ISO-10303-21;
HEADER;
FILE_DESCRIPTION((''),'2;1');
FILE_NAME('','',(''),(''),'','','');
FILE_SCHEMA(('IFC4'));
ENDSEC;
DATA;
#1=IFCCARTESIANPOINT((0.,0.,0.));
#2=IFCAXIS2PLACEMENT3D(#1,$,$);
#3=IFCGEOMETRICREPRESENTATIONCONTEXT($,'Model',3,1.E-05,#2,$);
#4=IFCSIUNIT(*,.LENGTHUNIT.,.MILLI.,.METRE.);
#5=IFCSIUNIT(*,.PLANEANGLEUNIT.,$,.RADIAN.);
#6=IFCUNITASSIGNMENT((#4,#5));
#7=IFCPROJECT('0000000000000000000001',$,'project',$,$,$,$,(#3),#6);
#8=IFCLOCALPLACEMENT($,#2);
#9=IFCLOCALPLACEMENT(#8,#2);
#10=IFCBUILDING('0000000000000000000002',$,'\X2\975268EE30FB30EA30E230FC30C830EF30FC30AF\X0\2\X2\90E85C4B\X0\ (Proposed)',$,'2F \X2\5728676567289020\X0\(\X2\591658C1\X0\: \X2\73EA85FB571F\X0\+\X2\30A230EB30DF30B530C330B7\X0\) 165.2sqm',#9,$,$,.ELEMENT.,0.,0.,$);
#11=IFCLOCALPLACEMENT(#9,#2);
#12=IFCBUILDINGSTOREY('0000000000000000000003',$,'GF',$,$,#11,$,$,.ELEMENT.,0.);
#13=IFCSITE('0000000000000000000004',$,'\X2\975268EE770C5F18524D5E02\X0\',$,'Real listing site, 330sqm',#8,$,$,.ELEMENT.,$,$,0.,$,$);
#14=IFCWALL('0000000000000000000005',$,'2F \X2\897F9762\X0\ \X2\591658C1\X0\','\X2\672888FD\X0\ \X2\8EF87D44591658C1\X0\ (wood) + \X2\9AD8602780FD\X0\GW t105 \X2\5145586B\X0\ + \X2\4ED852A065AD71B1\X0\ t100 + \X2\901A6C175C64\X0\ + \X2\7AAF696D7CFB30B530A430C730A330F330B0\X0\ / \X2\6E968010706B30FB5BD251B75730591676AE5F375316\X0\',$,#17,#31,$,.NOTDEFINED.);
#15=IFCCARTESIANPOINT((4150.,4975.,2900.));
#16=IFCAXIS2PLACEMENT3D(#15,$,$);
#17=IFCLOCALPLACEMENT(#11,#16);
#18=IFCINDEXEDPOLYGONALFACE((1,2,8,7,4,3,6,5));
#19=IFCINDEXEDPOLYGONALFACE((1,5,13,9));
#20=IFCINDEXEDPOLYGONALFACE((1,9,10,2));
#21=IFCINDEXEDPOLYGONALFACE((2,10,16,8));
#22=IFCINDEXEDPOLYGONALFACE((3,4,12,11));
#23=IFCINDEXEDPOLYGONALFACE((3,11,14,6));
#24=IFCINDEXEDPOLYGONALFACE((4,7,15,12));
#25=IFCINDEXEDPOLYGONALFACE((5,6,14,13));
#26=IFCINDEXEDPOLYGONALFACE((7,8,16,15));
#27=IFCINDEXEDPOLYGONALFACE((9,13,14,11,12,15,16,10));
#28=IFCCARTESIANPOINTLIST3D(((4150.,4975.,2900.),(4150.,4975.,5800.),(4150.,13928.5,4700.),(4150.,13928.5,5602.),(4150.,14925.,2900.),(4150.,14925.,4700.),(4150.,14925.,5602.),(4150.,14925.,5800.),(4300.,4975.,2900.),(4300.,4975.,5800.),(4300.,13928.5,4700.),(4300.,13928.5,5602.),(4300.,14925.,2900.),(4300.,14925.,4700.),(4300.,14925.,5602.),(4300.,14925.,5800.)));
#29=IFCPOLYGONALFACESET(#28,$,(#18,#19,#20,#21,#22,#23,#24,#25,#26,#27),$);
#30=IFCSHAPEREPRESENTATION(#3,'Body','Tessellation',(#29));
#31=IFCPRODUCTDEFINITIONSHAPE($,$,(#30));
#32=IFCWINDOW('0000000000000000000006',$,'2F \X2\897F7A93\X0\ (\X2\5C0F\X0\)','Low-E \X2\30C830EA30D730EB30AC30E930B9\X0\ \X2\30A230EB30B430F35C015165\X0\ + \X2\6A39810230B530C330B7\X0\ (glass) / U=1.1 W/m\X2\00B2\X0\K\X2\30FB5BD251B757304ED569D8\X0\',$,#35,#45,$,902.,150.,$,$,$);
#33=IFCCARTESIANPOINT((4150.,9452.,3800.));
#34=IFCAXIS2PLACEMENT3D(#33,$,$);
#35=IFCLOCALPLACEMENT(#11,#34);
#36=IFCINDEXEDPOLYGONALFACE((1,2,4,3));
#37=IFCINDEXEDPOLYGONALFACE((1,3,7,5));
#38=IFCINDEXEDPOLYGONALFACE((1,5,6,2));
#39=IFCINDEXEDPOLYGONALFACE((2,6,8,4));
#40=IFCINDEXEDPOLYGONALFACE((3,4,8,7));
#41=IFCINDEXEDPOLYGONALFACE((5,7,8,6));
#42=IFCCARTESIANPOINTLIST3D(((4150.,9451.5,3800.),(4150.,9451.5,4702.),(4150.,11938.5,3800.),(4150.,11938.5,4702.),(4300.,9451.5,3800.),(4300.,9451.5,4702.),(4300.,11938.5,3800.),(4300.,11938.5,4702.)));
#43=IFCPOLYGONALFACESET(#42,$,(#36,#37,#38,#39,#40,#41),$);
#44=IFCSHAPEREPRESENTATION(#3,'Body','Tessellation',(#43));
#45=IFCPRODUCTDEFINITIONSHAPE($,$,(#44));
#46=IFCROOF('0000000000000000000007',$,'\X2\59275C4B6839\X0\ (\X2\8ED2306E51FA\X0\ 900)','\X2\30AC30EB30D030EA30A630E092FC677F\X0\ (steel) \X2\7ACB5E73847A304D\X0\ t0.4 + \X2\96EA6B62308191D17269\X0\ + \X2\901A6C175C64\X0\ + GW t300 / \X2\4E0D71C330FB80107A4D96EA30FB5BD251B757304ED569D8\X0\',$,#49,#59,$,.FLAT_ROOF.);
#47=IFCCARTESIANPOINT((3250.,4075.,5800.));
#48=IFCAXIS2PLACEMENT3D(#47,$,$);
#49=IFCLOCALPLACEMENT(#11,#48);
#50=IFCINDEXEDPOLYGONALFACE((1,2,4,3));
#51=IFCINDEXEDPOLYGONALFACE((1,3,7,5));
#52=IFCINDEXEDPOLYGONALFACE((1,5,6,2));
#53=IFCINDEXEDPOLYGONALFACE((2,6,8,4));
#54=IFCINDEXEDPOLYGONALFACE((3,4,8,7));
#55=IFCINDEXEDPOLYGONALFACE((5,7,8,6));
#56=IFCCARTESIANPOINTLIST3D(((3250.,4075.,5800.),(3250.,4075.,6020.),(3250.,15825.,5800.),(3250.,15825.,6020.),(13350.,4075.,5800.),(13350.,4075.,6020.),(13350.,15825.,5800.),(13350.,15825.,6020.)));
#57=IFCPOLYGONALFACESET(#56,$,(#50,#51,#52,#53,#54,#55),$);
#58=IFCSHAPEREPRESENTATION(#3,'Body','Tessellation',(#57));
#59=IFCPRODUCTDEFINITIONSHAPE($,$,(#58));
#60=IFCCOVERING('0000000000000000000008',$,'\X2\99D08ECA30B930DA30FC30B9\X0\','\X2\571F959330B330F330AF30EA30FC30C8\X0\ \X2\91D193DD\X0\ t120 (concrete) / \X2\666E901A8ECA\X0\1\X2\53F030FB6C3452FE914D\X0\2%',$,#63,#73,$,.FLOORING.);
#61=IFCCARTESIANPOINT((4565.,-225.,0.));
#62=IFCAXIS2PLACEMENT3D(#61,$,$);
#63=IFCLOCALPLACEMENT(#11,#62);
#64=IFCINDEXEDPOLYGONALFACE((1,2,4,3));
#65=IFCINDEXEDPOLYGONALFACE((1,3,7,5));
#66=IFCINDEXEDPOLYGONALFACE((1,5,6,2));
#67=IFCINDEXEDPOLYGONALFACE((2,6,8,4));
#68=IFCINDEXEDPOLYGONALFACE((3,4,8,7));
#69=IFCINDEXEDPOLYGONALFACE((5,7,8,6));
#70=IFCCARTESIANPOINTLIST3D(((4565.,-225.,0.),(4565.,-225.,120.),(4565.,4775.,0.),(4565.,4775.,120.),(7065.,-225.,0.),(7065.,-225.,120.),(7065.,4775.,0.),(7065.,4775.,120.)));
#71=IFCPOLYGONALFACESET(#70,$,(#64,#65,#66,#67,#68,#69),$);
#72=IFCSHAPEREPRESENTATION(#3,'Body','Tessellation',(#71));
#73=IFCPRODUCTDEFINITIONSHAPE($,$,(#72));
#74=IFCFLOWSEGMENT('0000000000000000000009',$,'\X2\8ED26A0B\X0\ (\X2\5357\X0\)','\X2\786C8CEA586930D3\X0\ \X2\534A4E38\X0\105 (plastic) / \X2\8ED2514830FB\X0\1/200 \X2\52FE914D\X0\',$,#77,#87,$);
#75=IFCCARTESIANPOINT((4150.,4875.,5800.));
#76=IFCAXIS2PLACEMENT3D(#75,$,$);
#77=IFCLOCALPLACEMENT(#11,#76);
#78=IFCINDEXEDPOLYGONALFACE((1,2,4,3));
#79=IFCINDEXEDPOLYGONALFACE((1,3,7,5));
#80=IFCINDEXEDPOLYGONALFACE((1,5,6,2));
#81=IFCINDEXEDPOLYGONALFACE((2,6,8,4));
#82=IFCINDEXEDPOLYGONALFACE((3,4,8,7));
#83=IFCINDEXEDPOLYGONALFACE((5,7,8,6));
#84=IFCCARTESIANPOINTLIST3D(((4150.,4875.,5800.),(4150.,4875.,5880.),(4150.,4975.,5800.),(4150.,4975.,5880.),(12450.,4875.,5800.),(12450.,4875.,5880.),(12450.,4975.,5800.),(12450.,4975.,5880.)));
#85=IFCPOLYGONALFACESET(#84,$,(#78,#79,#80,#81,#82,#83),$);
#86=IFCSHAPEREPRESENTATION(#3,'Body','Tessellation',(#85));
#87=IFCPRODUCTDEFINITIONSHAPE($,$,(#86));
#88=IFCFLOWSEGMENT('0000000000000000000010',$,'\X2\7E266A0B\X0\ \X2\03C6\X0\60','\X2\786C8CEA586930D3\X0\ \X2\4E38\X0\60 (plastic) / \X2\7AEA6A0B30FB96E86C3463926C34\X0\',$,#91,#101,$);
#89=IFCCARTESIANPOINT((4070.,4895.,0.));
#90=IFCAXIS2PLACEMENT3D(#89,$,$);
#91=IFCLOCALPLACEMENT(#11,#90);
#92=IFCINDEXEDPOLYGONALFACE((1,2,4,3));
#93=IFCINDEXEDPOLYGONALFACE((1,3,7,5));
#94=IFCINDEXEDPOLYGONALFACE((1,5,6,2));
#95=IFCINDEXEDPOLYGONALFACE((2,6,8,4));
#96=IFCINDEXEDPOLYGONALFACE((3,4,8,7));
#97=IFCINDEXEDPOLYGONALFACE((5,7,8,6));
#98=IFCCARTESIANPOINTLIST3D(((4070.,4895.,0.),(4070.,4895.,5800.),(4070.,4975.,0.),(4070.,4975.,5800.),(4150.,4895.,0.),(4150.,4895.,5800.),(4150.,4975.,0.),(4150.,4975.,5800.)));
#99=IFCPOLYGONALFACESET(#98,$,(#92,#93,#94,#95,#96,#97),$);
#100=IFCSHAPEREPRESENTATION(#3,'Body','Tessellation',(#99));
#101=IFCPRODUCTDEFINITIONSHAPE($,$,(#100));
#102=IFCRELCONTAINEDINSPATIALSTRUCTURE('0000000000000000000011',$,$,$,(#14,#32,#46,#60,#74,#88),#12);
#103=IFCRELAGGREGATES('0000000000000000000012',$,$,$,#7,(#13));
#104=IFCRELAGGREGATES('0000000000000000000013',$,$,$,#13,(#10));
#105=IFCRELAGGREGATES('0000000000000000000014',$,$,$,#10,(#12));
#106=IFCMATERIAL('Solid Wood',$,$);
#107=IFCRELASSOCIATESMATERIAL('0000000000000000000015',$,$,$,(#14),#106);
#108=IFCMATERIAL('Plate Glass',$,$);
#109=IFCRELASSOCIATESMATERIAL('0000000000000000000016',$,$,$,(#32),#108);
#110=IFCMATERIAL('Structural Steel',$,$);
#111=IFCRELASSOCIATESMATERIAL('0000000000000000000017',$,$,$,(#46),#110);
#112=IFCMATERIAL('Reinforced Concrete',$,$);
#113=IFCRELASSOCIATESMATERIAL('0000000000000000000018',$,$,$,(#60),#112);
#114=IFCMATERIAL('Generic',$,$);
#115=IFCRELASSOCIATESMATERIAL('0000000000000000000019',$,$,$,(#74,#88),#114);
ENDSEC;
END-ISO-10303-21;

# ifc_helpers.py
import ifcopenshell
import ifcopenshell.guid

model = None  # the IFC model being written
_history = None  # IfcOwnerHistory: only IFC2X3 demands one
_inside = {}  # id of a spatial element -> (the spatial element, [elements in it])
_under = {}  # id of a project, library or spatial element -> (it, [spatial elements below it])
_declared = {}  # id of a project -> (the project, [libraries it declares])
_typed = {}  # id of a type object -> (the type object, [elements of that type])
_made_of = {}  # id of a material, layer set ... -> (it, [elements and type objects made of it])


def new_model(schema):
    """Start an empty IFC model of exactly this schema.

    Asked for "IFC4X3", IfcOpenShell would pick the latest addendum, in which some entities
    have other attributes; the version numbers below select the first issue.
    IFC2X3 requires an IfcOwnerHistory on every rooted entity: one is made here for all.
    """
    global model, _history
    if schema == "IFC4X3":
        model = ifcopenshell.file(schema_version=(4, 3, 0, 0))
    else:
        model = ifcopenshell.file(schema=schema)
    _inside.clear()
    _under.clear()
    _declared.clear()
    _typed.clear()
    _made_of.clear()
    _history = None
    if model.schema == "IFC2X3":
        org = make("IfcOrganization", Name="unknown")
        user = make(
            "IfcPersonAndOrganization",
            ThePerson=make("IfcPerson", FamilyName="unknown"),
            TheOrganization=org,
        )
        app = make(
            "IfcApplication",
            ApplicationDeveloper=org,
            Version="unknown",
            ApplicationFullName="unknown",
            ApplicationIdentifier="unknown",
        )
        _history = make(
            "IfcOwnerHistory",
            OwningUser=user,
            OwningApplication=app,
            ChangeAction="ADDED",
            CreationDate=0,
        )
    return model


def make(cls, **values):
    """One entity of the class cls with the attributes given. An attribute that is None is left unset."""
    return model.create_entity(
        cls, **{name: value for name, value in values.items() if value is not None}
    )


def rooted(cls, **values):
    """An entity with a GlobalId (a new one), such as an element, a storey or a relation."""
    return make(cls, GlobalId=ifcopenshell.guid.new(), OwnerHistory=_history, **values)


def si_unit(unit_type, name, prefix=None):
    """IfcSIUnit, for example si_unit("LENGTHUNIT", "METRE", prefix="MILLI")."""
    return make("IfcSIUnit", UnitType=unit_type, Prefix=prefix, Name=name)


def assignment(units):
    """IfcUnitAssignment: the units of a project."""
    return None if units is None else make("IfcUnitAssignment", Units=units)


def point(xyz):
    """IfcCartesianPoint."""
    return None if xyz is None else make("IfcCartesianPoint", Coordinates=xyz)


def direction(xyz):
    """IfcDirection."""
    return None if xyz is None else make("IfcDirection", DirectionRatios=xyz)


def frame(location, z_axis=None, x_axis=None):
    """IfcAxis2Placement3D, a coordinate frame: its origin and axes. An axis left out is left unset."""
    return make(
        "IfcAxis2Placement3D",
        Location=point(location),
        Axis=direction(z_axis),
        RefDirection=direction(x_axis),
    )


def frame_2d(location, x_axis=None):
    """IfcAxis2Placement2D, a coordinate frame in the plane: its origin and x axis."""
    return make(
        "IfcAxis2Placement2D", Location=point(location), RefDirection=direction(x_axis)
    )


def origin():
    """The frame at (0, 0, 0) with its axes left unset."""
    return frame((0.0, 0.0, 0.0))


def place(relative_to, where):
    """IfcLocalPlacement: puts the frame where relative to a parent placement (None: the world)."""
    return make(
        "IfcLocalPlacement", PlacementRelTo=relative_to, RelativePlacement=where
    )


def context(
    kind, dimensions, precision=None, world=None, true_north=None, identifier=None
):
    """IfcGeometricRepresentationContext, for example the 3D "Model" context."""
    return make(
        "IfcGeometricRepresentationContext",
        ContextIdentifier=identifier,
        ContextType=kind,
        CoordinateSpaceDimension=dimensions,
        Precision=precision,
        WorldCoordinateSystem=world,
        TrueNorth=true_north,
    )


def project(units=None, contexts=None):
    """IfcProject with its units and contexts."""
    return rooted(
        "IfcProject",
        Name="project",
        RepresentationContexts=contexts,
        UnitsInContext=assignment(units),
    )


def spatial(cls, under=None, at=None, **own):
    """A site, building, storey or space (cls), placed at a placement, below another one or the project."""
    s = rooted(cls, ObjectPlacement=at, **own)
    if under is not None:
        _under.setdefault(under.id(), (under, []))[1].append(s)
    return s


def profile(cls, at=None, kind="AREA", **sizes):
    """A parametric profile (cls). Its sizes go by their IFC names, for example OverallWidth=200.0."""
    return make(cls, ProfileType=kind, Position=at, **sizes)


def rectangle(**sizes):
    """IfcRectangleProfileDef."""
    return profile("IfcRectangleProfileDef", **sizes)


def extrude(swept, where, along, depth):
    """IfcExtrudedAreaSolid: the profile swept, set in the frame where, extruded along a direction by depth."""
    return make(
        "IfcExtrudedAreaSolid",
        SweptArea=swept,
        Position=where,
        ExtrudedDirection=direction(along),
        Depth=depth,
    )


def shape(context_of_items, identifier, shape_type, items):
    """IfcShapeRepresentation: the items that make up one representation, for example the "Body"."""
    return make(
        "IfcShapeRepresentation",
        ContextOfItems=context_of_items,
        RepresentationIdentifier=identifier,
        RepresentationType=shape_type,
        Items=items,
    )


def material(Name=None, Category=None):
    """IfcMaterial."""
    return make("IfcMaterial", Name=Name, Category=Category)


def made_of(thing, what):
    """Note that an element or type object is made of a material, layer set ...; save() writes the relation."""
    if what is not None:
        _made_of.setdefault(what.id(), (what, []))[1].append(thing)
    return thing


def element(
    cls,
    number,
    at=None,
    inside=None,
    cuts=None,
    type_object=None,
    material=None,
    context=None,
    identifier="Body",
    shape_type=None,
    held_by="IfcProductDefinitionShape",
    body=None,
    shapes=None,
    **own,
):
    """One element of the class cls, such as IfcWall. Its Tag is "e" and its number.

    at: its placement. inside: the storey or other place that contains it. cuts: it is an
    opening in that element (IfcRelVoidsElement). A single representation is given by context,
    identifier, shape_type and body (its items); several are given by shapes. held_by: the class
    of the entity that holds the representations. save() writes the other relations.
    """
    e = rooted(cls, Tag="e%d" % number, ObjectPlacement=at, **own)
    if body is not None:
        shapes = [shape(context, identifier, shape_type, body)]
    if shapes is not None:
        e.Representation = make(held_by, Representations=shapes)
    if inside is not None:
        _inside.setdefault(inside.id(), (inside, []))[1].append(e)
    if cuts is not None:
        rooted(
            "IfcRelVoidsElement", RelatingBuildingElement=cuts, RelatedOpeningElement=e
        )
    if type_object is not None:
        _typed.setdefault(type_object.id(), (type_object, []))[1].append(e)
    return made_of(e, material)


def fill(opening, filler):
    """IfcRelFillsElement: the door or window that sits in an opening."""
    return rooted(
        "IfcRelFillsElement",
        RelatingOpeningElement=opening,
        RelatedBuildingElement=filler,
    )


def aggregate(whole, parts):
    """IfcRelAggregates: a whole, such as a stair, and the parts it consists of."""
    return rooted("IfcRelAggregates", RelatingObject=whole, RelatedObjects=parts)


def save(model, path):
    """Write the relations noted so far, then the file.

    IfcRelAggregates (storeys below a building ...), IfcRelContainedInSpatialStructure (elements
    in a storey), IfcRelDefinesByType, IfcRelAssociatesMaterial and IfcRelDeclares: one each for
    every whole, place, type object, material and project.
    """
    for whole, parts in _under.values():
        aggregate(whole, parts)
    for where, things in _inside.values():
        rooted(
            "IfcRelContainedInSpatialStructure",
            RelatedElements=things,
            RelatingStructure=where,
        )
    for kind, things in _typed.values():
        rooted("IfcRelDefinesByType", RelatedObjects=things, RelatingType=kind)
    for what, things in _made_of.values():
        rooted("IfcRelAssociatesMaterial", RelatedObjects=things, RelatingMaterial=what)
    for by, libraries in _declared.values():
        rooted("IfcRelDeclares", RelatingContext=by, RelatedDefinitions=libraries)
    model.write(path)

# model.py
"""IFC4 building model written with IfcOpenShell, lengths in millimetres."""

from ifc_helpers import new_model, si_unit, frame, frame_2d, origin, place, context, project, spatial, rectangle, extrude, material, element, fill, save


model = new_model("IFC4")

# Units and contexts
model_context = context("Model", 3, precision=1e-05, world=origin())
ifc_project = project(units=[si_unit("LENGTHUNIT", "METRE", prefix="MILLI"), si_unit("PLANEANGLEUNIT", "RADIAN")], contexts=[model_context])

# Site, building, storey
site_placement = place(None, origin())
site = spatial("IfcSite", under=ifc_project, at=site_placement, Name="青森県弘前市", ObjectType="Real listing site, 330sqm", CompositionType="ELEMENT", RefElevation=0.0)
building_placement = place(site_placement, origin())
building = spatial("IfcBuilding", under=site, at=building_placement, Name="青森・リモートワーク2部屋 (Proposed)", ObjectType="2F 在来木造(外壁: 珪藻土+アルミサッシ) 165.2sqm", CompositionType="ELEMENT", ElevationOfRefHeight=0.0, ElevationOfTerrain=0.0)
storey_placement = place(building_placement, origin())
storey = spatial("IfcBuildingStorey", under=building, at=storey_placement, Name="GF", CompositionType="ELEMENT", Elevation=0.0)

# Shared definitions
ifc_material_1 = material(Name="Solid Wood")

# Shared definitions
ifc_material_2 = material(Name="Reinforced Concrete")

# Shared definitions
ifc_material_3 = material(Name="Plate Glass")

# Wall, opening, window
wall_1_placement = place(storey_placement, frame((4150.0, 4975.0, 2900.0)))
wall_1 = element("IfcWall", 1, at=wall_1_placement, inside=storey, material=ifc_material_1, Name="2F 西面 外壁", Description="木製 軸組外壁 (wood) + 高性能GW t105 充填 + 付加断熱 t100 + 通気層 + 窯業系サイディング / 準耐火・寒冷地外皮強化", PredefinedType="NOTDEFINED", context=model_context, shape_type="SweptSolid", body=[
    extrude(rectangle(XDim=150.0, YDim=9950.0, at=frame_2d((75.0, 4975.0))), frame((4150.0, 4975.0, 2900.0)), (0.0, 0.0, 1.0), 2900.0),
])
opening_1_placement = place(storey_placement, frame((4150.0, 9452.0, 3800.0)))
opening_1 = element("IfcOpeningElement", 2, at=opening_1_placement, cuts=wall_1, PredefinedType="NOTDEFINED", context=model_context, shape_type="SweptSolid", body=[
    extrude(rectangle(XDim=150.0, YDim=2487.0, at=frame_2d((75.0, 1243.0))), frame((4150.0, 9452.0, 3800.0)), (0.0, 0.0, 1.0), 902.0),
])
window_1_placement = place(storey_placement, frame((4150.0, 9452.0, 3800.0)))
window_1 = element("IfcWindow", 3, at=window_1_placement, inside=storey, material=ifc_material_3, Name="2F 西窓 (小)", Description="Low-E トリプルガラス アルゴン封入 + 樹脂サッシ (glass) / U=1.1 W/m²K・寒冷地仕様", OverallHeight=902.0, OverallWidth=150.0, context=model_context, shape_type="SweptSolid", body=[
    extrude(rectangle(XDim=150.0, YDim=2487.0, at=frame_2d((75.0, 1243.0))), frame((4150.0, 9452.0, 3800.0)), (0.0, 0.0, 1.0), 902.0),
])
fill(opening_1, window_1)

# Roof
ifc_material_4 = material(Name="Structural Steel")
roof_placement = place(storey_placement, frame((3250.0, 4075.0, 5800.0)))
element("IfcRoof", 4, at=roof_placement, inside=storey, material=ifc_material_4, Name="大屋根 (軒の出 900)", Description="ガルバリウム鋼板 (steel) 立平葺き t0.4 + 雪止め金物 + 通気層 + GW t300 / 不燃・耐積雪・寒冷地仕様", PredefinedType="FLAT_ROOF", context=model_context, shape_type="SweptSolid", body=[
    extrude(rectangle(XDim=10100.0, YDim=11750.0, at=frame_2d((5050.0, 5875.0))), frame((3250.0, 4075.0, 5800.0)), (0.0, 0.0, 1.0), 220.0),
])

# Covering
covering_placement = place(storey_placement, frame((4565.0, -225.0, 0.0)))
element("IfcCovering", 5, at=covering_placement, inside=storey, material=ifc_material_2, Name="駐車スペース", Description="土間コンクリート 金鏝 t120 (concrete) / 普通車1台・水勾配2%", PredefinedType="FLOORING", context=model_context, shape_type="SweptSolid", body=[
    extrude(rectangle(XDim=2500.0, YDim=5000.0, at=frame_2d((1250.0, 2500.0))), frame((4565.0, -225.0, 0.0)), (0.0, 0.0, 1.0), 120.0),
])

# Flow segments
ifc_material_5 = material(Name="Generic")
flow_segment_1_placement = place(storey_placement, frame((4150.0, 4875.0, 5800.0)))
element("IfcFlowSegment", 6, at=flow_segment_1_placement, inside=storey, material=ifc_material_5, Name="軒樋 (南)", Description="硬質塩ビ 半丸105 (plastic) / 軒先・1/200 勾配", context=model_context, shape_type="SweptSolid", body=[
    extrude(rectangle(XDim=8300.0, YDim=100.0, at=frame_2d((4150.0, 50.0))), frame((4150.0, 4875.0, 5800.0)), (0.0, 0.0, 1.0), 80.0),
])
flow_segment_2_placement = place(storey_placement, frame((4070.0, 4895.0, 0.0)))
element("IfcFlowSegment", 7, at=flow_segment_2_placement, inside=storey, material=ifc_material_5, Name="縦樋 φ60", Description="硬質塩ビ 丸60 (plastic) / 竪樋・雨水排水", context=model_context, shape_type="SweptSolid", body=[
    extrude(rectangle(XDim=80.0, YDim=80.0, at=frame_2d((40.0, 40.0))), frame((4070.0, 4895.0, 0.0)), (0.0, 0.0, 1.0), 5800.0),
])

save(model, "model.ifc")
